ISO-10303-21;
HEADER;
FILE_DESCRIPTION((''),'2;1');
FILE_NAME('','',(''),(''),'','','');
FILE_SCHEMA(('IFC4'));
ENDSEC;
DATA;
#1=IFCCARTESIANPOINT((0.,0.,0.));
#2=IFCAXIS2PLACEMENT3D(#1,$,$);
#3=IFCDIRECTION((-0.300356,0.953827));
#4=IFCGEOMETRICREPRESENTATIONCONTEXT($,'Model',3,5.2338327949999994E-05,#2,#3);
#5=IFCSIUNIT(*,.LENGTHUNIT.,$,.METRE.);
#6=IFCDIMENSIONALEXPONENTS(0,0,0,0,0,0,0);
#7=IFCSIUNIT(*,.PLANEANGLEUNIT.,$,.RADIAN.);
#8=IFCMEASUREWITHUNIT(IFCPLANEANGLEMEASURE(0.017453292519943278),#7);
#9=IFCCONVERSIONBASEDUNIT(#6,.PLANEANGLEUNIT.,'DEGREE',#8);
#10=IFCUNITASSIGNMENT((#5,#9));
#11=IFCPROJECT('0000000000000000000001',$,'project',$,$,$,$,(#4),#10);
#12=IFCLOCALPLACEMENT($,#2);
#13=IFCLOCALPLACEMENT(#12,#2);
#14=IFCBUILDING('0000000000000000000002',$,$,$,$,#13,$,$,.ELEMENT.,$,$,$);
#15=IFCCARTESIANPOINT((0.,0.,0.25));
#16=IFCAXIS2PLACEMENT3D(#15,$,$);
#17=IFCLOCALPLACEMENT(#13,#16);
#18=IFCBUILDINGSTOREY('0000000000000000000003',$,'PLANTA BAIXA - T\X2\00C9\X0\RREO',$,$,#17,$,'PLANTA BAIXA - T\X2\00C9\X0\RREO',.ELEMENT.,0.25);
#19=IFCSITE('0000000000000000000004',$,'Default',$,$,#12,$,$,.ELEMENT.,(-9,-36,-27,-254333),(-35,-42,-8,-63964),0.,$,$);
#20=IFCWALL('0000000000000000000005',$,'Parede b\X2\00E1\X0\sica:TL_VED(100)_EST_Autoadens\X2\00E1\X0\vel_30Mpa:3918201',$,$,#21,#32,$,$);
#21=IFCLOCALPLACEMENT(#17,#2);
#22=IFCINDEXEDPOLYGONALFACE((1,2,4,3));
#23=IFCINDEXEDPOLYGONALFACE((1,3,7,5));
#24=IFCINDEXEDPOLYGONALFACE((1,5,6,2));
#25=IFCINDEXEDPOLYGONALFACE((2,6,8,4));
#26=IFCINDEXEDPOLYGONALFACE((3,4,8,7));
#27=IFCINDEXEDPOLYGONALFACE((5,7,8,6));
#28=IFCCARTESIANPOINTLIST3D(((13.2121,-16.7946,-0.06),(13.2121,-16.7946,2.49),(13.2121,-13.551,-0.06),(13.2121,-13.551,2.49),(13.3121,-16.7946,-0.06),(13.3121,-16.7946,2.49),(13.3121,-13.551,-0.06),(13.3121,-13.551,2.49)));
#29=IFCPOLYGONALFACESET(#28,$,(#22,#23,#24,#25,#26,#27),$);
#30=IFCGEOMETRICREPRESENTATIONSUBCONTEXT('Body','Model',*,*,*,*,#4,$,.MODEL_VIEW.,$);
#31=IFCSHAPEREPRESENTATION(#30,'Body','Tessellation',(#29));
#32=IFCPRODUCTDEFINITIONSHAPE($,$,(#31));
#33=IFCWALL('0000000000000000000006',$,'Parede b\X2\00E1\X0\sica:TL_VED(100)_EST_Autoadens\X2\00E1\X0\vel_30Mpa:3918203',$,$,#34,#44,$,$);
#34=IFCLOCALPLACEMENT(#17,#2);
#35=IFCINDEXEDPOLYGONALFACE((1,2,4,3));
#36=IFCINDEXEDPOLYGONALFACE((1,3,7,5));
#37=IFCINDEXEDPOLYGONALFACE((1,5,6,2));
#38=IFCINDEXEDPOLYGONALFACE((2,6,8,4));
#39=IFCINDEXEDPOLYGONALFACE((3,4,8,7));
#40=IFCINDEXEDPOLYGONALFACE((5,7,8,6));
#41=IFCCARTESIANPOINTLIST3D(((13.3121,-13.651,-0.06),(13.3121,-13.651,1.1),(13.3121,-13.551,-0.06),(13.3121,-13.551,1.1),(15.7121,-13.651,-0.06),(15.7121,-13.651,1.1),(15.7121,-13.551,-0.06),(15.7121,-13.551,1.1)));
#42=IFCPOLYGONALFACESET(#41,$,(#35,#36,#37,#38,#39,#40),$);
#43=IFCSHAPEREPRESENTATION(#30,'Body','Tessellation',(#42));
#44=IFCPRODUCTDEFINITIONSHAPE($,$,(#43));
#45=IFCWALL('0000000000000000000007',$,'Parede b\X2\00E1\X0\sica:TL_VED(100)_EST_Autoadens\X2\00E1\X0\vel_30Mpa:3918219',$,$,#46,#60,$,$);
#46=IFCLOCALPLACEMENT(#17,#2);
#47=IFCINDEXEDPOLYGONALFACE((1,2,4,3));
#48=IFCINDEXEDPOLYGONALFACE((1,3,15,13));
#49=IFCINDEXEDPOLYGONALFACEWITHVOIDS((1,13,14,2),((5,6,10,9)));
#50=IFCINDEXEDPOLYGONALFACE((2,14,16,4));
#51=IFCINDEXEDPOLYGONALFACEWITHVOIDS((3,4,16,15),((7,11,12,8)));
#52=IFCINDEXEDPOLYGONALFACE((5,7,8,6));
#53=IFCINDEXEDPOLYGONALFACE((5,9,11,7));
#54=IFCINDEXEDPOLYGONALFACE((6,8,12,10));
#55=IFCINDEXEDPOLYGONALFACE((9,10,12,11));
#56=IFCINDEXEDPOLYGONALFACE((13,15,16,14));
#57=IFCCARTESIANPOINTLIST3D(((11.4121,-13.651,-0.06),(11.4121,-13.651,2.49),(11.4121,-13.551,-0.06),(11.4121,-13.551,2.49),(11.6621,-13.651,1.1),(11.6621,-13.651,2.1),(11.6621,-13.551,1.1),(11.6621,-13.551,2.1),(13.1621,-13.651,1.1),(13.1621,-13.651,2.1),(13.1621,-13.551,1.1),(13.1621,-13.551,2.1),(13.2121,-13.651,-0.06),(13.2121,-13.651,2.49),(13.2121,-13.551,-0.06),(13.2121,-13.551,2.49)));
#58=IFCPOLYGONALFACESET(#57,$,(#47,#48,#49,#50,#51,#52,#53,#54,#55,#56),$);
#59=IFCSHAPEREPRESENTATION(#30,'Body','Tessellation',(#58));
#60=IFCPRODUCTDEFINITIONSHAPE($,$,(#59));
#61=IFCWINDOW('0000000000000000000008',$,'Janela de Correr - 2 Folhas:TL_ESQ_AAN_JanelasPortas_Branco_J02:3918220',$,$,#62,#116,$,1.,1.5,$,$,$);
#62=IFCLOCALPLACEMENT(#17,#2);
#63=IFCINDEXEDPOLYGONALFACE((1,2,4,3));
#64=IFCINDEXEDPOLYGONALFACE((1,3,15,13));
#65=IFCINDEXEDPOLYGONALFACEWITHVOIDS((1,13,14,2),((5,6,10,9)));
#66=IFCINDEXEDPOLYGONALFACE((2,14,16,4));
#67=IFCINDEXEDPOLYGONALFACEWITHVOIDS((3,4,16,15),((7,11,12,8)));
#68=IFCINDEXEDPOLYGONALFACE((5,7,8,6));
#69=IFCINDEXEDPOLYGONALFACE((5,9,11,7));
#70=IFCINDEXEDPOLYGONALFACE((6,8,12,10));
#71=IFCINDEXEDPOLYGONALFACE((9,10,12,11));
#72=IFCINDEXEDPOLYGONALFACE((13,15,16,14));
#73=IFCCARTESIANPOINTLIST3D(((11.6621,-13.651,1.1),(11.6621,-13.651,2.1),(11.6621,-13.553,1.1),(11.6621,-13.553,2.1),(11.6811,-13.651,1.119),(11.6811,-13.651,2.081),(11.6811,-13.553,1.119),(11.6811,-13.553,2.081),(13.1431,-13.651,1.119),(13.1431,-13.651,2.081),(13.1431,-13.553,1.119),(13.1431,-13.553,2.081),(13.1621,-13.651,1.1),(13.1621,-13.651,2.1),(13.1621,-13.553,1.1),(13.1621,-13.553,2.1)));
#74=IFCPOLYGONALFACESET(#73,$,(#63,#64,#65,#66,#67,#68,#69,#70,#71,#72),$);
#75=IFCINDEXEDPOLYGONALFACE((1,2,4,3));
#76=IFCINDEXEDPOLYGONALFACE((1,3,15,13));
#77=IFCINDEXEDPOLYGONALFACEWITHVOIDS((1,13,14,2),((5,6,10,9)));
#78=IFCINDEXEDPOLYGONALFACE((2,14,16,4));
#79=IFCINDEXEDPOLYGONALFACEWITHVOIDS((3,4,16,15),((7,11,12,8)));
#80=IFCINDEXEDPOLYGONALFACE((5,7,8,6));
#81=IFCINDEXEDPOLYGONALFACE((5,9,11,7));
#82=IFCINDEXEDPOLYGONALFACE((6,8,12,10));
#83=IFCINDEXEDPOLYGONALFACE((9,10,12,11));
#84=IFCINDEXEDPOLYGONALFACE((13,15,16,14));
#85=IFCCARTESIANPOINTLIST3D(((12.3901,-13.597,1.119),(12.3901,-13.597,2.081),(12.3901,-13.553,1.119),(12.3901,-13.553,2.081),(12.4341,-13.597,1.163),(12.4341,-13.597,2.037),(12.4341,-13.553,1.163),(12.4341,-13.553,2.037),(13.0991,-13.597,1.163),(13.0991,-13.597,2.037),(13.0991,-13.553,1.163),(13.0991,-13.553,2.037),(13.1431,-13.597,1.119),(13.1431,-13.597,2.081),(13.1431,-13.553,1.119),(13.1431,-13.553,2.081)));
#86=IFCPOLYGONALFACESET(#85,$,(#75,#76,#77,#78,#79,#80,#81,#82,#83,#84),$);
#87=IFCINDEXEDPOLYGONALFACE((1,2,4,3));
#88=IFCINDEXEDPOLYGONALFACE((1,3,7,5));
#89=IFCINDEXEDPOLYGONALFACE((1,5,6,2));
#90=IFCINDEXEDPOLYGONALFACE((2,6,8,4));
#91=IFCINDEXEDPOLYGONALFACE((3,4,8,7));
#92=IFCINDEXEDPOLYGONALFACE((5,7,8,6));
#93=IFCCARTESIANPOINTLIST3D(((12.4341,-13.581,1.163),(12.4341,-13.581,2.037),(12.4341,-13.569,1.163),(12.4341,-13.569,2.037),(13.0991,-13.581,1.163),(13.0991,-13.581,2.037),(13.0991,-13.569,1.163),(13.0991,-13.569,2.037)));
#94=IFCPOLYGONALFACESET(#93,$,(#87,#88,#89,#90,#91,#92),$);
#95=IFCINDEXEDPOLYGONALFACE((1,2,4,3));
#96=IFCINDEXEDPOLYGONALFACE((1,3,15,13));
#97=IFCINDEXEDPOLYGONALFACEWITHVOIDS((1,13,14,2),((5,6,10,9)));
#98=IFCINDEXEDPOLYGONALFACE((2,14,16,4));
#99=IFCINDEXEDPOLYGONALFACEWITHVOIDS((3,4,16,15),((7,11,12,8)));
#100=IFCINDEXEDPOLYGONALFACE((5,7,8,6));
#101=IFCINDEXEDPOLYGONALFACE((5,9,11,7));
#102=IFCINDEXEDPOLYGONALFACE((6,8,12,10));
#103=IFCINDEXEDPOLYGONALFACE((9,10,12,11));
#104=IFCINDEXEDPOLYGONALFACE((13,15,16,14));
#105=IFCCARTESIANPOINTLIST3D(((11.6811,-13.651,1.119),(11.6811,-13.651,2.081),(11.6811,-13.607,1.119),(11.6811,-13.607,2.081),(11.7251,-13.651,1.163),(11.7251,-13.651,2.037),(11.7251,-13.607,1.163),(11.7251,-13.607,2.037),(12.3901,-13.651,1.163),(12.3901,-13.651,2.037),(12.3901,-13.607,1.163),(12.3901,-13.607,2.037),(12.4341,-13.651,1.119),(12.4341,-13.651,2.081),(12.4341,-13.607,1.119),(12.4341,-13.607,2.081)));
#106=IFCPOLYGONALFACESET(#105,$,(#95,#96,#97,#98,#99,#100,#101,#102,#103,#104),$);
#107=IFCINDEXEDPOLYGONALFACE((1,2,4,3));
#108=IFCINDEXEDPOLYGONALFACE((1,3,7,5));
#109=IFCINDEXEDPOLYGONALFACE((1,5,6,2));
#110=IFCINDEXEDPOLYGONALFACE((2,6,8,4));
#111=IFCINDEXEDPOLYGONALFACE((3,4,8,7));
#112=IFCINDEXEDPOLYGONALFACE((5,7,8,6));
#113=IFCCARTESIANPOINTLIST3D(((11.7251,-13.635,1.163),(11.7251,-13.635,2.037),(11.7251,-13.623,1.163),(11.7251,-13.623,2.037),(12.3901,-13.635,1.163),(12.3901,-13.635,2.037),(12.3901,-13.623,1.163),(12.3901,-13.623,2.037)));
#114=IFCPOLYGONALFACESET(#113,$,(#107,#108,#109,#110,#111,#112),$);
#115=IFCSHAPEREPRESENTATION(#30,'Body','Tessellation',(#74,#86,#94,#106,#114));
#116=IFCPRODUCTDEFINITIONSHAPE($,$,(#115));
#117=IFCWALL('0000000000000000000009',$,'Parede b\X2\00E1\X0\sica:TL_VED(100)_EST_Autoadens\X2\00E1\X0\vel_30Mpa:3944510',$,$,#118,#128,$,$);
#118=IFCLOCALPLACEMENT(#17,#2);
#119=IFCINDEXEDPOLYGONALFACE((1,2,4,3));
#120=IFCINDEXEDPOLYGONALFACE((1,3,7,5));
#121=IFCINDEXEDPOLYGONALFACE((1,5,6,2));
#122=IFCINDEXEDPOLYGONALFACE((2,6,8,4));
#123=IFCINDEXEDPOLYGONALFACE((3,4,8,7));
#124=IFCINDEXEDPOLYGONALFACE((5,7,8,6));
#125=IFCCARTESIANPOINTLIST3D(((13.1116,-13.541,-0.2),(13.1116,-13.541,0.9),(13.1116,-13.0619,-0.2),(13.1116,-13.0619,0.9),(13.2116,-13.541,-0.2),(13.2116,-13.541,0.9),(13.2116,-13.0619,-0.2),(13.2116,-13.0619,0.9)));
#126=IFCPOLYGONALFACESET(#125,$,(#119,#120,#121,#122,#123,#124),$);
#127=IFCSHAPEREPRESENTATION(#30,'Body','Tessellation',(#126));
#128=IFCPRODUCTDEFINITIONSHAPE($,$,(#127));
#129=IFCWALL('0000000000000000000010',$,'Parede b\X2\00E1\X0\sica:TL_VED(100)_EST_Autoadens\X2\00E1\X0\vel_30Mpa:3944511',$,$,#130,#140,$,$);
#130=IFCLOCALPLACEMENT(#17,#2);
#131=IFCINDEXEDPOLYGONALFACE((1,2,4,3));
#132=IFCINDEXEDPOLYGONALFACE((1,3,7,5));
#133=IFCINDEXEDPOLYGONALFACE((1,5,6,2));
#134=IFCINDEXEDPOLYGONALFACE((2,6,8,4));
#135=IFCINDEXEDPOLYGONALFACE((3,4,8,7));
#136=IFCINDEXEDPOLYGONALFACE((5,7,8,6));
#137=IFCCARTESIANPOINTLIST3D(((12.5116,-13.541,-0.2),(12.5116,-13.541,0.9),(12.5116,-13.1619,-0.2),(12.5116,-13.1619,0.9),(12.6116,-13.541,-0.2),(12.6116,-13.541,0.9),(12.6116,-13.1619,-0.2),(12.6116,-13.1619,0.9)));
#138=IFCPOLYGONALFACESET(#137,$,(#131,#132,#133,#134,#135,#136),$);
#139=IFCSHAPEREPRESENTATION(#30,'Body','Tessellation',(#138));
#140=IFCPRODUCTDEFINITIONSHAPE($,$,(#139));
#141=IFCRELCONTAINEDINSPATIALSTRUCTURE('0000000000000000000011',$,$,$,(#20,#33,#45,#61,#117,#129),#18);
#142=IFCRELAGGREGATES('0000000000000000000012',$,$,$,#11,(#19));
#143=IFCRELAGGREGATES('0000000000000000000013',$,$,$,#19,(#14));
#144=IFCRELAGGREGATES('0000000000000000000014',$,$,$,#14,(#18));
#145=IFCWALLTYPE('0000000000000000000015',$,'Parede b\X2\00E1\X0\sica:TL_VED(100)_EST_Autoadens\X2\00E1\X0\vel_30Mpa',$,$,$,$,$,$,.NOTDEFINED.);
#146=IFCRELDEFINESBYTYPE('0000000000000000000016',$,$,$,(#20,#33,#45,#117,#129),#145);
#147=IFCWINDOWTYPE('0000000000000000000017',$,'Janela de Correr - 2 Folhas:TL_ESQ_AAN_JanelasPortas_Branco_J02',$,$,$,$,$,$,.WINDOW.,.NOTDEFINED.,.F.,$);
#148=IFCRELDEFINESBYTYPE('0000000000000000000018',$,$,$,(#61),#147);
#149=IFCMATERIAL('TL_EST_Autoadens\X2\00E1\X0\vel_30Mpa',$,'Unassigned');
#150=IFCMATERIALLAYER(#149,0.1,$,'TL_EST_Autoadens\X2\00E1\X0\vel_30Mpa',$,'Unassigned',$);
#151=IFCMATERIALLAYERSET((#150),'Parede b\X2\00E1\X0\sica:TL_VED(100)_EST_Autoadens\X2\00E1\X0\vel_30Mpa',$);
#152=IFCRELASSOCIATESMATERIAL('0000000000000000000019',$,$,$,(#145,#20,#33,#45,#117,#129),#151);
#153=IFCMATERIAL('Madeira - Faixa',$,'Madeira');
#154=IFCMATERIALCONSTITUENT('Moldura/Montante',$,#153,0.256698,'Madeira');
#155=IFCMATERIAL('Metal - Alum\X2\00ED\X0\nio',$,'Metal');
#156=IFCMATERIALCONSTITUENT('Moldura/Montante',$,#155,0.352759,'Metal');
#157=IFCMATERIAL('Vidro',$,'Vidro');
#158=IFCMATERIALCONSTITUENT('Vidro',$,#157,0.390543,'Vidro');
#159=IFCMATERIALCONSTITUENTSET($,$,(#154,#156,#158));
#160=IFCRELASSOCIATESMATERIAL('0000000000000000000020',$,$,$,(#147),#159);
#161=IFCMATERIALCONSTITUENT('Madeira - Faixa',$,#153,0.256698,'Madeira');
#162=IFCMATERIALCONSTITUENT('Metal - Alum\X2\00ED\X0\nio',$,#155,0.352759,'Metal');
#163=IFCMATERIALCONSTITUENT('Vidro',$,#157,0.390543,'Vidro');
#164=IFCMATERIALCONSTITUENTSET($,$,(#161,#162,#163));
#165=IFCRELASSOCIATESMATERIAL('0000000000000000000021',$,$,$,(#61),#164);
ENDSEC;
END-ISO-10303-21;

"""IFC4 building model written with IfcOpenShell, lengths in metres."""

from ifc_helpers import new_model, entity, si_unit, converted_unit, direction, frame, frame_2d, origin, origin_2d_with_axis, place, context, subcontext, project, spatial, polyline, rectangle, outline, extrude, clip, bounded_halfspace, source, transform, mapped, material, layer, layer_set, layer_usage, constituent, constituent_set, type_object, type_shapes, element, fill, save


model = new_model("IFC4")

# Units and contexts
model_context = context("Model", 3, precision=5.2338327949999994e-05, world=origin(), true_north=direction((-0.300356, 0.953827)))
body_context = subcontext(model_context, "Body", "Model", "MODEL_VIEW")
ifc_project = project(units=[si_unit("LENGTHUNIT", "METRE"), converted_unit("PLANEANGLEUNIT", "DEGREE", entity("IfcPlaneAngleMeasure", 0.017453292519943278), si_unit("PLANEANGLEUNIT", "RADIAN"), dimensions=[0, 0, 0, 0, 0, 0, 0])], contexts=[model_context])

# Site, building, storey
site_placement = place(None, origin())
site = spatial("IfcSite", under=ifc_project, at=site_placement, Name="Default", CompositionType="ELEMENT", RefLatitude=(-9, -36, -27, -254333), RefLongitude=(-35, -42, -8, -63964), RefElevation=0.0)
building_placement = place(site_placement, origin())
building = spatial("IfcBuilding", under=site, at=building_placement, CompositionType="ELEMENT")
storey_placement = place(building_placement, frame((0.0, 0.0, 0.25)))
storey = spatial("IfcBuildingStorey", under=building, at=storey_placement, Name="PLANTA BAIXA - TÉRREO", LongName="PLANTA BAIXA - TÉRREO", CompositionType="ELEMENT", Elevation=0.25)

# Wall
ifc_material_1 = material(Name="TL_EST_Autoadensável_30Mpa", Category="Unassigned")
ifc_layer_1 = layer(ifc_material_1, 0.1, Name="TL_EST_Autoadensável_30Mpa", Category="Unassigned")
ifc_layer_set_1 = layer_set([ifc_layer_1], Name="Parede básica:TL_VED(100)_EST_Autoadensável_30Mpa")
ifc_layer_usage_1 = layer_usage(ifc_layer_set_1, "AXIS2", "POSITIVE", -0.05)
wall_type_1 = type_object("IfcWallType", Name="Parede básica:TL_VED(100)_EST_Autoadensável_30Mpa", PredefinedType="NOTDEFINED", material=ifc_layer_set_1)
wall_1_placement = place(storey_placement, frame((13.2621, -13.551, -0.06), z_axis=(0.0, 0.0, 1.0), x_axis=(0.0, -1.0, 0.0)))
element("IfcWall", 1, at=wall_1_placement, inside=storey, type_object=wall_type_1, material=ifc_layer_usage_1, Name="Parede básica:TL_VED(100)_EST_Autoadensável_30Mpa:3918201", context=body_context, shape_type="SweptSolid", body=[
    extrude(rectangle(XDim=3.2437, YDim=0.1, at=frame_2d((1.6218, 0.0), x_axis=(-1.0, 0.0))), origin(), (0.0, 0.0, 1.0), 2.55),
])

# Wall
ifc_layer_usage_2 = layer_usage(ifc_layer_set_1, "AXIS2", "POSITIVE", -0.05)
wall_2_placement = place(storey_placement, frame((15.7121, -13.601, -0.06), z_axis=(0.0, 0.0, 1.0), x_axis=(-1.0, 0.0, 0.0)))
element("IfcWall", 2, at=wall_2_placement, inside=storey, type_object=wall_type_1, material=ifc_layer_usage_2, Name="Parede básica:TL_VED(100)_EST_Autoadensável_30Mpa:3918203", context=body_context, shape_type="SweptSolid", body=[
    extrude(rectangle(XDim=2.4, YDim=0.1, at=frame_2d((1.2, 0.0), x_axis=(-1.0, 0.0))), origin(), (0.0, 0.0, 1.0), 1.16),
])

# Wall, opening, window
ifc_layer_usage_3 = layer_usage(ifc_layer_set_1, "AXIS2", "POSITIVE", -0.05)
wall_3_placement = place(storey_placement, frame((13.2121, -13.601, -0.06), z_axis=(0.0, 0.0, 1.0), x_axis=(-1.0, 0.0, 0.0)))
wall_3 = element("IfcWall", 3, at=wall_3_placement, inside=storey, type_object=wall_type_1, material=ifc_layer_usage_3, Name="Parede básica:TL_VED(100)_EST_Autoadensável_30Mpa:3918219", context=body_context, shape_type="SweptSolid", body=[
    extrude(rectangle(XDim=1.8, YDim=0.1, at=frame_2d((0.9, 0.0), x_axis=(-1.0, 0.0))), origin(), (0.0, 0.0, 1.0), 2.55),
])
opening_1_placement = place(wall_3_placement, frame((1.55, 0.05, 1.16)))
opening_1 = element("IfcOpeningElement", 4, at=opening_1_placement, cuts=wall_3, PredefinedType="OPENING", context=body_context, shape_type="SweptSolid", body=[
    extrude(rectangle(XDim=1.0, YDim=1.5, at=frame_2d((0.5, 0.75), x_axis=(-1.0, 0.0))), frame((0.0, 0.0, 0.0), z_axis=(0.0, -1.0, 0.0), x_axis=(0.0, 0.0, 1.0)), (0.0, 0.0, 1.0), 0.1),
])
ifc_material_2 = material(Name="Madeira - Faixa", Category="Madeira")
ifc_constituent_1 = constituent(ifc_material_2, Name="Madeira - Faixa", Category="Madeira", fraction=0.256698)
ifc_material_3 = material(Name="Metal - Alumínio", Category="Metal")
ifc_constituent_2 = constituent(ifc_material_3, Name="Metal - Alumínio", Category="Metal", fraction=0.352759)
ifc_material_4 = material(Name="Vidro", Category="Vidro")
ifc_constituent_3 = constituent(ifc_material_4, Name="Vidro", Category="Vidro", fraction=0.390543)
ifc_constituent_set_1 = constituent_set(constituents=[ifc_constituent_1, ifc_constituent_2, ifc_constituent_3])
ifc_constituent_4 = constituent(ifc_material_2, Name="Moldura/Montante", Category="Madeira", fraction=0.256698)
ifc_constituent_5 = constituent(ifc_material_3, Name="Moldura/Montante", Category="Metal", fraction=0.352759)
ifc_constituent_6 = constituent(ifc_material_4, Name="Vidro", Category="Vidro", fraction=0.390543)
ifc_constituent_set_2 = constituent_set(constituents=[ifc_constituent_4, ifc_constituent_5, ifc_constituent_6])
window_type = type_object("IfcWindowType", Name="Janela de Correr - 2 Folhas:TL_ESQ_AAN_JanelasPortas_Branco_J02", ParameterTakesPrecedence=False, PartitioningType="NOTDEFINED", PredefinedType="WINDOW", material=ifc_constituent_set_2)
shared_shape = source(origin(), body_context, "Body", "SweptSolid", [
    extrude(outline(polyline([(-0.75, -0.5), (0.75, -0.5), (0.75, 0.5), (-0.75, 0.5), (-0.75, -0.5)]), holes=[polyline([(-0.731, -0.481), (-0.731, 0.481), (0.731, 0.481), (0.731, -0.481), (-0.731, -0.481)])]), frame((0.75, 0.0, 0.5), z_axis=(0.0, 1.0, 0.0), x_axis=(1.0, 0.0, 0.0)), (0.0, 0.0, 1.0), 0.098),
    extrude(outline(polyline([(-0.3765, -0.481), (0.3765, -0.481), (0.3765, 0.481), (-0.3765, 0.481), (-0.3765, -0.481)]), holes=[polyline([(-0.3325, -0.437), (-0.3325, 0.437), (0.3325, 0.437), (0.3325, -0.437), (-0.3325, -0.437)])]), frame((1.1045, 0.054, 0.5), z_axis=(0.0, 1.0, 0.0), x_axis=(1.0, 0.0, 0.0)), (0.0, 0.0, 1.0), 0.044),
    extrude(rectangle(XDim=0.012, YDim=0.665, at=origin_2d_with_axis()), frame((1.1045, 0.076, 0.063), z_axis=(0.0, 0.0, 1.0), x_axis=(0.0, -1.0, 0.0)), (0.0, 0.0, 1.0), 0.874),
    extrude(outline(polyline([(-0.481, -0.3765), (0.481, -0.3765), (0.481, 0.3765), (-0.481, 0.3765), (-0.481, -0.3765)]), holes=[polyline([(-0.437, -0.3325), (-0.437, 0.3325), (0.437, 0.3325), (0.437, -0.3325), (-0.437, -0.3325)])]), frame((0.3955, 0.0, 0.5), z_axis=(0.0, 1.0, 0.0), x_axis=(0.0, 0.0, -1.0)), (0.0, 0.0, 1.0), 0.044),
    extrude(rectangle(XDim=0.012, YDim=0.665, at=origin_2d_with_axis()), frame((0.3955, 0.022, 0.063), z_axis=(0.0, 0.0, 1.0), x_axis=(0.0, -1.0, 0.0)), (0.0, 0.0, 1.0), 0.874),
])
type_shapes(window_type, [shared_shape])
window_placement = place(opening_1_placement, frame((0.0, 0.0, 0.0), z_axis=(0.0, 0.0, 1.0), x_axis=(-1.0, 0.0, 0.0)))
window = element("IfcWindow", 5, at=window_placement, inside=storey, type_object=window_type, material=ifc_constituent_set_1, Name="Janela de Correr - 2 Folhas:TL_ESQ_AAN_JanelasPortas_Branco_J02:3918220", OverallHeight=1.0, OverallWidth=1.5, context=body_context, shape_type="MappedRepresentation", body=[
    mapped(shared_shape, transform((0.0, 0.0, 0.0), scale=1.0)),
])
fill(opening_1, window)

# Walls
ifc_layer_usage_4 = layer_usage(ifc_layer_set_1, "AXIS2", "POSITIVE", -0.05)
wall_4_placement = place(storey_placement, frame((13.1616, -13.0619, -0.2), z_axis=(0.0, 0.0, 1.0), x_axis=(0.0, -1.0, 0.0)))
element("IfcWall", 6, at=wall_4_placement, inside=storey, type_object=wall_type_1, material=ifc_layer_usage_4, Name="Parede básica:TL_VED(100)_EST_Autoadensável_30Mpa:3944510", context=body_context, shape_type="Clipping", body=[
    clip(extrude(rectangle(XDim=0.4791, YDim=0.1, at=frame_2d((0.2395, 0.0), x_axis=(-1.0, 0.0))), origin(), (0.0, 0.0, 1.0), 1.1), bounded_halfspace(frame((0.0, -0.05, 1.1), z_axis=(0.0, 0.0, -1.0), x_axis=(0.0, 1.0, 0.0)), True, frame((0.0, -0.05, 1.1)), polyline([(0.0, 0.0), (0.1, 0.0), (0.4791, 0.0), (0.4791, 0.1), (0.0, 0.1), (0.0, 0.0)]))),
])
ifc_layer_usage_5 = layer_usage(ifc_layer_set_1, "AXIS2", "POSITIVE", -0.05)
wall_5_placement = place(storey_placement, frame((12.5616, -13.1619, -0.2), z_axis=(0.0, 0.0, 1.0), x_axis=(0.0, -1.0, 0.0)))
element("IfcWall", 7, at=wall_5_placement, inside=storey, type_object=wall_type_1, material=ifc_layer_usage_5, Name="Parede básica:TL_VED(100)_EST_Autoadensável_30Mpa:3944511", context=body_context, shape_type="Clipping", body=[
    clip(extrude(rectangle(XDim=0.3791, YDim=0.1, at=frame_2d((0.1895, 0.0), x_axis=(-1.0, 0.0))), origin(), (0.0, 0.0, 1.0), 1.1), bounded_halfspace(frame((0.0, -0.05, 1.1), z_axis=(0.0, 0.0, -1.0), x_axis=(0.0, 1.0, 0.0)), True, frame((0.0, -0.05, 1.1)), polyline([(0.0, 0.0), (0.3791, 0.0), (0.3791, 0.1), (0.0, 0.1), (0.0, 0.0)]))),
])

save(model, "model.ifc")
